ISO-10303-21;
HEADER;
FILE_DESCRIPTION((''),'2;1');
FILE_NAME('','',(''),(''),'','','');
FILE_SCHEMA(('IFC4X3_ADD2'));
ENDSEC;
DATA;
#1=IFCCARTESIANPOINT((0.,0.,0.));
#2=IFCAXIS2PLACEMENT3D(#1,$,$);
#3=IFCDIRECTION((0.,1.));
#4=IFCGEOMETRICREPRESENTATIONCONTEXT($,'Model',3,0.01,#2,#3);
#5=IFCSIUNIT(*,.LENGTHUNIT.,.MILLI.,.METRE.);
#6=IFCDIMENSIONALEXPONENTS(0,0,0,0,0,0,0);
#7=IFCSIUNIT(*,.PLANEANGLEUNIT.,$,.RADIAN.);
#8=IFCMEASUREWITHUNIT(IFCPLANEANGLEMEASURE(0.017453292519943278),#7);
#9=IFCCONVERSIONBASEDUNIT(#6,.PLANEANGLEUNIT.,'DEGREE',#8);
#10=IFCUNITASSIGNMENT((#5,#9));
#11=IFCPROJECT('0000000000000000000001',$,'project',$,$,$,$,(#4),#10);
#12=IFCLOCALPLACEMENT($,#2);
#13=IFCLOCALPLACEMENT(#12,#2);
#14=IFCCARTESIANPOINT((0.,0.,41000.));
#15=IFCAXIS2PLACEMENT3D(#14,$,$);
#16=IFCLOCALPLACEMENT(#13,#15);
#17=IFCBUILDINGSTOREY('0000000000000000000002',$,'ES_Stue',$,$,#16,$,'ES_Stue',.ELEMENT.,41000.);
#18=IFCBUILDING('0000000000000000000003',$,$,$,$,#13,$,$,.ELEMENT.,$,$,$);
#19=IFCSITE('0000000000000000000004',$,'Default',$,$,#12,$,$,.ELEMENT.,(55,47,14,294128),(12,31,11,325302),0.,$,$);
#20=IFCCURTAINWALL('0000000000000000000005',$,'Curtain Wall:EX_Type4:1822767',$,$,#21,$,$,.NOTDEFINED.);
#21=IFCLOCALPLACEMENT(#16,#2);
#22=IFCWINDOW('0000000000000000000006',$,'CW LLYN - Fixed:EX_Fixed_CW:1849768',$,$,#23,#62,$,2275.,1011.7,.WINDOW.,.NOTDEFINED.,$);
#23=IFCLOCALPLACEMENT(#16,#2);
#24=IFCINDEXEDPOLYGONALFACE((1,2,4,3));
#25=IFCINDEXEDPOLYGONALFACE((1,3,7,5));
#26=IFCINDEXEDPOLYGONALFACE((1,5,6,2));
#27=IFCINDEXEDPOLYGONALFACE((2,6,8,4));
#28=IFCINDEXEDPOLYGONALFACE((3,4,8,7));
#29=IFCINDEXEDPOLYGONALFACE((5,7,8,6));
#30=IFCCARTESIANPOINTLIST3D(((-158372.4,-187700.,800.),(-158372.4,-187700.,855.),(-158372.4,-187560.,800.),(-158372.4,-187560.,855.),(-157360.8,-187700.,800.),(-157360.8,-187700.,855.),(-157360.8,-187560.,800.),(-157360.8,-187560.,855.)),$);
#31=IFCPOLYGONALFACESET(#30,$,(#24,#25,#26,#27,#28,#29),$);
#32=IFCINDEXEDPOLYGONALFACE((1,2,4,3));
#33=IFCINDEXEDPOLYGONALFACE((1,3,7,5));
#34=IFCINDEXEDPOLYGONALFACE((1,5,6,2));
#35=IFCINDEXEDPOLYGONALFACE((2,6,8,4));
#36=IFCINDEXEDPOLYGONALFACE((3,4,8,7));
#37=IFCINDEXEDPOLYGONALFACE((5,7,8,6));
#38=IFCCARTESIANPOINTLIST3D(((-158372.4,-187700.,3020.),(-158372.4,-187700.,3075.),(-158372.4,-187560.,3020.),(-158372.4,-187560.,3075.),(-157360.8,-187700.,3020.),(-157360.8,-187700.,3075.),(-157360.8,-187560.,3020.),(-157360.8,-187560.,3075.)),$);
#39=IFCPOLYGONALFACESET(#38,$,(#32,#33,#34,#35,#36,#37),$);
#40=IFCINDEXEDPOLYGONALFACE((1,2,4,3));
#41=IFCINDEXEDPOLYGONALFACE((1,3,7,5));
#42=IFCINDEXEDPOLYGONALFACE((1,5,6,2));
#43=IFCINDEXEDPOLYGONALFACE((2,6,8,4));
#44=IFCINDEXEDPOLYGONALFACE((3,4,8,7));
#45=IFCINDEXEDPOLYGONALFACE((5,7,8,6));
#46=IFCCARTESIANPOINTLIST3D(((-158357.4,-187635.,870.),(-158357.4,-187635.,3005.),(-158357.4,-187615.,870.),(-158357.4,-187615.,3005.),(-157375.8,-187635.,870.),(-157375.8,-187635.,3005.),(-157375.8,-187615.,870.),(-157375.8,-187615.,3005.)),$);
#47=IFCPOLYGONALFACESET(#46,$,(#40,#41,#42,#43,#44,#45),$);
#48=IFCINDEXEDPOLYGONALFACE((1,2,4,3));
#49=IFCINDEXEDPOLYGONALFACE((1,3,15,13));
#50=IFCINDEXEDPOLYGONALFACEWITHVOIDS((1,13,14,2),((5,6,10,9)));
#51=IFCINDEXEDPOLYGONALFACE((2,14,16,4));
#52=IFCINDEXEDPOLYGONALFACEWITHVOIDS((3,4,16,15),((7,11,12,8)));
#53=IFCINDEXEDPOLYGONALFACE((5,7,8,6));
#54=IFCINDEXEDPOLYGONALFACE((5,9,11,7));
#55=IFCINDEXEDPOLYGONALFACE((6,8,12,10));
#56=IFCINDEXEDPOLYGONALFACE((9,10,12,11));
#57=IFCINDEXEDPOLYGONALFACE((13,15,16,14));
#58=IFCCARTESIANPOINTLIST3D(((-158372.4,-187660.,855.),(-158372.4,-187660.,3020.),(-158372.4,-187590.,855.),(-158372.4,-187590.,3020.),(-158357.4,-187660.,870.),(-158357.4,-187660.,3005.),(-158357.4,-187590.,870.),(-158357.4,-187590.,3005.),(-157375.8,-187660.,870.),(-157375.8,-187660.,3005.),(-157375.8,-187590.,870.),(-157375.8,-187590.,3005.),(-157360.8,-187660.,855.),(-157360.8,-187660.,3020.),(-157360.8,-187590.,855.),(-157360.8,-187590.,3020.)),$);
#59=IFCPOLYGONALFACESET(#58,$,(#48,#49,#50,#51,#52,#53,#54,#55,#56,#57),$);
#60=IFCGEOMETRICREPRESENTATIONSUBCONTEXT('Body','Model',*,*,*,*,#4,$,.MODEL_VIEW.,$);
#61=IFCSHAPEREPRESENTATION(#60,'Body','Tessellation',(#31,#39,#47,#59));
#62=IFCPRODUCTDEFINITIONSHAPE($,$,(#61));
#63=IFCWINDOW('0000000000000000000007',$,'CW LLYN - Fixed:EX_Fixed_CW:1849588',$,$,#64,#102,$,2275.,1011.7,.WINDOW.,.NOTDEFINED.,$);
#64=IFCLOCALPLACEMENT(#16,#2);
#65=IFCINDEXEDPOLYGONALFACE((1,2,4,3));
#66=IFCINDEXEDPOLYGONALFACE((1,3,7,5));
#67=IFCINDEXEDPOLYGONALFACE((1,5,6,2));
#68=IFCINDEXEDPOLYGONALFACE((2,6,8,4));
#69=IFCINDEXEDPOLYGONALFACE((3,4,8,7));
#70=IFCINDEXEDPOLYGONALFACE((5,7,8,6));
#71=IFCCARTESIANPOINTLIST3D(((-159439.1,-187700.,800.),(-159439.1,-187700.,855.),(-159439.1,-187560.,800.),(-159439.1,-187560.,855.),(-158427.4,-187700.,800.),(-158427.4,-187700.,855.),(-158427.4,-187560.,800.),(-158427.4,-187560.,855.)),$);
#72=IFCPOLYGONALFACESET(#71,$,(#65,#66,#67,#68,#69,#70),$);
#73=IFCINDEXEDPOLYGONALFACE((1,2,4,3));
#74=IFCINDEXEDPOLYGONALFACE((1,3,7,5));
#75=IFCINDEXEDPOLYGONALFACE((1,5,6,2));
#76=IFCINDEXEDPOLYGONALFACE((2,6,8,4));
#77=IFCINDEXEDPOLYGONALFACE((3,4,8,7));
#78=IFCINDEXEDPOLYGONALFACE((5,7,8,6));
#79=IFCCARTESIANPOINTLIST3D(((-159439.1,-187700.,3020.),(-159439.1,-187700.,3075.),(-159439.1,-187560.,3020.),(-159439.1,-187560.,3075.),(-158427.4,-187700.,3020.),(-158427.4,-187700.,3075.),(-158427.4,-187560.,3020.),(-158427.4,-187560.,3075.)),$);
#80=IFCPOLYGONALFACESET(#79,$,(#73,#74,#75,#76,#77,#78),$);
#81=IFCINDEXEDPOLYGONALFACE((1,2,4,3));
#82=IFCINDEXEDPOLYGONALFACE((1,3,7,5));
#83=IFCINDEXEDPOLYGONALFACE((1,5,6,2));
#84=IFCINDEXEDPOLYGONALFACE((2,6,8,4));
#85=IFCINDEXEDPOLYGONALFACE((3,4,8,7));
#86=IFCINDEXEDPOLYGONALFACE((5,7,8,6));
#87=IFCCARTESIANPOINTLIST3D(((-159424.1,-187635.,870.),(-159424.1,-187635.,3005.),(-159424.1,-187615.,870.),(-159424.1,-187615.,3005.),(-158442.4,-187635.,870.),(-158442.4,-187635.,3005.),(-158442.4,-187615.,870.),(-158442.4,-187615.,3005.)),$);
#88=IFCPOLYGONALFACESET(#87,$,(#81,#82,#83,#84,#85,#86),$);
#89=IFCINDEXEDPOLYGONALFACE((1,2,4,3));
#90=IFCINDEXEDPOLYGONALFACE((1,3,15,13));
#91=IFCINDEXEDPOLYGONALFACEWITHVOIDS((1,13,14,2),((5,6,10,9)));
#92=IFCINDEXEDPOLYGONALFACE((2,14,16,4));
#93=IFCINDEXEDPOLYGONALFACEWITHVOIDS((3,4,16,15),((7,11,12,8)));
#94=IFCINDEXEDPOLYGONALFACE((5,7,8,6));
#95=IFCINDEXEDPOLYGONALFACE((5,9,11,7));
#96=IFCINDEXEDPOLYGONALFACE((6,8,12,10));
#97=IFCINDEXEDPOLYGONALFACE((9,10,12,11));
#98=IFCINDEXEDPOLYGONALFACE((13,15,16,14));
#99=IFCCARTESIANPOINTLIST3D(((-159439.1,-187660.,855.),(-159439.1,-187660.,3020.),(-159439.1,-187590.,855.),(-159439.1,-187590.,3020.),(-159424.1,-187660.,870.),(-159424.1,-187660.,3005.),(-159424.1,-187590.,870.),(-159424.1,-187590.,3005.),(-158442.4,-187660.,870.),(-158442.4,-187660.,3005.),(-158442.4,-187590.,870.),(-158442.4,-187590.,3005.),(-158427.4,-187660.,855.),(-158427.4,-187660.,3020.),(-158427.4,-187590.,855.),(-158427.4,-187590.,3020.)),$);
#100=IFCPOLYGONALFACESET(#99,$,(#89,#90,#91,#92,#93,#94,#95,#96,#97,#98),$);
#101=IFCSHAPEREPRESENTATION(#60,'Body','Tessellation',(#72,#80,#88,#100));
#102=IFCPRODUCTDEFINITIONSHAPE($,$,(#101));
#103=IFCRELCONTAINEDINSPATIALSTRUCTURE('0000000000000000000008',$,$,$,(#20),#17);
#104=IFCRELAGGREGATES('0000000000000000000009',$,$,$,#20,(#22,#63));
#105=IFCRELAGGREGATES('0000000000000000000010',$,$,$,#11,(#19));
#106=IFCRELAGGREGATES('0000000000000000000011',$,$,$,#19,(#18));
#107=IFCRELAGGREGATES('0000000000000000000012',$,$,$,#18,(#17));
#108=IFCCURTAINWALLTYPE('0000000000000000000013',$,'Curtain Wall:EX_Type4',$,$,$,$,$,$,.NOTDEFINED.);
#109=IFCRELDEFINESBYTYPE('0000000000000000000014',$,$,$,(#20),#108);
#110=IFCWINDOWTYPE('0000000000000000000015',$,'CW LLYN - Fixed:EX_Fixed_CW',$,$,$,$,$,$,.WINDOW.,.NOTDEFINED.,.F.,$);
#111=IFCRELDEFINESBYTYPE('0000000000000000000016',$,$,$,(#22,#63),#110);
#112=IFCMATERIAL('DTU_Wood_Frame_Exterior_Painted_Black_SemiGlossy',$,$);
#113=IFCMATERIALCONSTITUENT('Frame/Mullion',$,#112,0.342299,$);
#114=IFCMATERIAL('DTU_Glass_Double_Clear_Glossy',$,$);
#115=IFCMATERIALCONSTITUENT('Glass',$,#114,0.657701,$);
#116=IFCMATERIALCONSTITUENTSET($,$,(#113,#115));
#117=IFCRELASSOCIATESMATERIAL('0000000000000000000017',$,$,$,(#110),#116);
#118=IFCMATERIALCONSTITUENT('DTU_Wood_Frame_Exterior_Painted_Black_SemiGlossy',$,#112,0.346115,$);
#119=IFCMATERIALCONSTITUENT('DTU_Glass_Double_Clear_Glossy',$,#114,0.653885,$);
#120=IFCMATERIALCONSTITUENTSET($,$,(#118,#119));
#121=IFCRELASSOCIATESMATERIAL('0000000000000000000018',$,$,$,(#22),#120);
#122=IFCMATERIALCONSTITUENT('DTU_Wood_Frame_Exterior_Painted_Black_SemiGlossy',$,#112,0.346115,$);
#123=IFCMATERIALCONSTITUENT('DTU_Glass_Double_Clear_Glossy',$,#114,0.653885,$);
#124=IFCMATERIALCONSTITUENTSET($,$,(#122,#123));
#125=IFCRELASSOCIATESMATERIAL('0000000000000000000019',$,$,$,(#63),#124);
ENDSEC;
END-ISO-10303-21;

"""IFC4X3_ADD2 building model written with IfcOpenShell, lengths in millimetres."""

from ifc_helpers import new_model, entity, si_unit, converted_unit, direction, frame, frame_2d, origin, origin_2d_with_axis, place, context, subcontext, project, spatial, polyline, rectangle, outline, extrude, source, transform, mapped, material, constituent, constituent_set, type_object, type_shapes, element, aggregate, save


model = new_model("IFC4X3_ADD2")

# Units and contexts
model_context = context("Model", 3, precision=0.01, world=origin(), true_north=direction((0.0, 1.0)))
body_context = subcontext(model_context, "Body", "Model", "MODEL_VIEW")
ifc_project = project(units=[si_unit("LENGTHUNIT", "METRE", prefix="MILLI"), converted_unit("PLANEANGLEUNIT", "DEGREE", entity("IfcPlaneAngleMeasure", 0.017453292519943278), si_unit("PLANEANGLEUNIT", "RADIAN"), dimensions=[0, 0, 0, 0, 0, 0, 0])], contexts=[model_context])

# Site, building, storey
site_placement = place(None, origin())
site = spatial("IfcSite", under=ifc_project, at=site_placement, Name="Default", CompositionType="ELEMENT", RefLatitude=(55, 47, 14, 294128), RefLongitude=(12, 31, 11, 325302), RefElevation=0.0)
building_placement = place(site_placement, origin())
building = spatial("IfcBuilding", under=site, at=building_placement, CompositionType="ELEMENT")
storey_placement = place(building_placement, frame((0.0, 0.0, 41000.0)))
storey = spatial("IfcBuildingStorey", under=building, at=storey_placement, Name="ES_Stue", LongName="ES_Stue", CompositionType="ELEMENT", Elevation=41000.0)

# Curtain wall
curtain_wall_type = type_object("IfcCurtainWallType", Name="Curtain Wall:EX_Type4", PredefinedType="NOTDEFINED")
curtain_wall_placement = place(storey_placement, frame((0.0, 0.0, -41000.0)))
curtain_wall = element("IfcCurtainWall", 1, at=curtain_wall_placement, inside=storey, type_object=curtain_wall_type, Name="Curtain Wall:EX_Type4:1822767", PredefinedType="NOTDEFINED")

# Windows
ifc_material_1 = material(Name="DTU_Wood_Frame_Exterior_Painted_Black_SemiGlossy")
ifc_constituent_1 = constituent(ifc_material_1, Name="DTU_Wood_Frame_Exterior_Painted_Black_SemiGlossy", fraction=0.346115)
ifc_material_2 = material(Name="DTU_Glass_Double_Clear_Glossy")
ifc_constituent_2 = constituent(ifc_material_2, Name="DTU_Glass_Double_Clear_Glossy", fraction=0.653885)
ifc_constituent_set_1 = constituent_set(constituents=[ifc_constituent_1, ifc_constituent_2])
ifc_constituent_3 = constituent(ifc_material_1, Name="Frame/Mullion", fraction=0.342299)
ifc_constituent_4 = constituent(ifc_material_2, Name="Glass", fraction=0.657701)
ifc_constituent_set_2 = constituent_set(constituents=[ifc_constituent_3, ifc_constituent_4])
window_type_1 = type_object("IfcWindowType", Name="CW LLYN - Fixed:EX_Fixed_CW", ParameterTakesPrecedence=False, PartitioningType="NOTDEFINED", PredefinedType="WINDOW", material=ifc_constituent_set_2)
shared_shape_1 = source(origin(), body_context, "Body", "SweptSolid", [
    extrude(rectangle(XDim=140.0, YDim=1011.7, at=origin_2d_with_axis()), frame((0.0, -130.0, 0.0), z_axis=(0.0, 0.0, 1.0), x_axis=(0.0, -1.0, 0.0)), (0.0, 0.0, 1.0), 55.0),
    extrude(rectangle(XDim=140.0, YDim=1011.7, at=frame_2d((0.0, 0.0), x_axis=(1.0, 0.0))), frame((0.0, -130.0, 2220.0), z_axis=(0.0, 0.0, 1.0), x_axis=(0.0, -1.0, 0.0)), (0.0, 0.0, 1.0), 55.0),
    extrude(rectangle(XDim=981.7, YDim=20.0, at=frame_2d((0.0, 0.0), x_axis=(1.0, 0.0))), frame((0.0, -125.0, 70.0), z_axis=(0.0, 0.0, 1.0), x_axis=(-1.0, 0.0, 0.0)), (0.0, 0.0, 1.0), 2135.0),
    extrude(outline(polyline([(-1082.5, -505.8), (1082.5, -505.8), (1082.5, 505.8), (-1082.5, 505.8), (-1082.5, -505.8)]), holes=[polyline([(-1067.5, 490.8), (1067.5, 490.8), (1067.5, -490.8), (-1067.5, -490.8), (-1067.5, 490.8)])]), frame((0.0, -90.0, 1137.5), z_axis=(0.0, -1.0, 0.0), x_axis=(0.0, 0.0, 1.0)), (0.0, 0.0, 1.0), 70.0),
])
type_shapes(window_type_1, [shared_shape_1])
window_1_placement = place(curtain_wall_placement, frame((-157866.6, -187500.0, 41800.0)))
window_1 = element("IfcWindow", 2, at=window_1_placement, type_object=window_type_1, material=ifc_constituent_set_1, Name="CW LLYN - Fixed:EX_Fixed_CW:1849768", OverallHeight=2275.0, OverallWidth=1011.7, PartitioningType="NOTDEFINED", PredefinedType="WINDOW", context=body_context, shape_type="MappedRepresentation", body=[
    mapped(shared_shape_1, transform((0.0, 0.0, 0.0), scale=1.0)),
])
ifc_constituent_5 = constituent(ifc_material_1, Name="DTU_Wood_Frame_Exterior_Painted_Black_SemiGlossy", fraction=0.346115)
ifc_constituent_6 = constituent(ifc_material_2, Name="DTU_Glass_Double_Clear_Glossy", fraction=0.653885)
ifc_constituent_set_3 = constituent_set(constituents=[ifc_constituent_5, ifc_constituent_6])
window_2_placement = place(curtain_wall_placement, frame((-158933.3, -187500.0, 41800.0)))
window_2 = element("IfcWindow", 3, at=window_2_placement, type_object=window_type_1, material=ifc_constituent_set_3, Name="CW LLYN - Fixed:EX_Fixed_CW:1849588", OverallHeight=2275.0, OverallWidth=1011.7, PartitioningType="NOTDEFINED", PredefinedType="WINDOW", context=body_context, shape_type="MappedRepresentation", body=[
    mapped(shared_shape_1, transform((0.0, 0.0, 0.0), scale=1.0)),
])

aggregate(curtain_wall, [window_1, window_2])

save(model, "model.ifc")
